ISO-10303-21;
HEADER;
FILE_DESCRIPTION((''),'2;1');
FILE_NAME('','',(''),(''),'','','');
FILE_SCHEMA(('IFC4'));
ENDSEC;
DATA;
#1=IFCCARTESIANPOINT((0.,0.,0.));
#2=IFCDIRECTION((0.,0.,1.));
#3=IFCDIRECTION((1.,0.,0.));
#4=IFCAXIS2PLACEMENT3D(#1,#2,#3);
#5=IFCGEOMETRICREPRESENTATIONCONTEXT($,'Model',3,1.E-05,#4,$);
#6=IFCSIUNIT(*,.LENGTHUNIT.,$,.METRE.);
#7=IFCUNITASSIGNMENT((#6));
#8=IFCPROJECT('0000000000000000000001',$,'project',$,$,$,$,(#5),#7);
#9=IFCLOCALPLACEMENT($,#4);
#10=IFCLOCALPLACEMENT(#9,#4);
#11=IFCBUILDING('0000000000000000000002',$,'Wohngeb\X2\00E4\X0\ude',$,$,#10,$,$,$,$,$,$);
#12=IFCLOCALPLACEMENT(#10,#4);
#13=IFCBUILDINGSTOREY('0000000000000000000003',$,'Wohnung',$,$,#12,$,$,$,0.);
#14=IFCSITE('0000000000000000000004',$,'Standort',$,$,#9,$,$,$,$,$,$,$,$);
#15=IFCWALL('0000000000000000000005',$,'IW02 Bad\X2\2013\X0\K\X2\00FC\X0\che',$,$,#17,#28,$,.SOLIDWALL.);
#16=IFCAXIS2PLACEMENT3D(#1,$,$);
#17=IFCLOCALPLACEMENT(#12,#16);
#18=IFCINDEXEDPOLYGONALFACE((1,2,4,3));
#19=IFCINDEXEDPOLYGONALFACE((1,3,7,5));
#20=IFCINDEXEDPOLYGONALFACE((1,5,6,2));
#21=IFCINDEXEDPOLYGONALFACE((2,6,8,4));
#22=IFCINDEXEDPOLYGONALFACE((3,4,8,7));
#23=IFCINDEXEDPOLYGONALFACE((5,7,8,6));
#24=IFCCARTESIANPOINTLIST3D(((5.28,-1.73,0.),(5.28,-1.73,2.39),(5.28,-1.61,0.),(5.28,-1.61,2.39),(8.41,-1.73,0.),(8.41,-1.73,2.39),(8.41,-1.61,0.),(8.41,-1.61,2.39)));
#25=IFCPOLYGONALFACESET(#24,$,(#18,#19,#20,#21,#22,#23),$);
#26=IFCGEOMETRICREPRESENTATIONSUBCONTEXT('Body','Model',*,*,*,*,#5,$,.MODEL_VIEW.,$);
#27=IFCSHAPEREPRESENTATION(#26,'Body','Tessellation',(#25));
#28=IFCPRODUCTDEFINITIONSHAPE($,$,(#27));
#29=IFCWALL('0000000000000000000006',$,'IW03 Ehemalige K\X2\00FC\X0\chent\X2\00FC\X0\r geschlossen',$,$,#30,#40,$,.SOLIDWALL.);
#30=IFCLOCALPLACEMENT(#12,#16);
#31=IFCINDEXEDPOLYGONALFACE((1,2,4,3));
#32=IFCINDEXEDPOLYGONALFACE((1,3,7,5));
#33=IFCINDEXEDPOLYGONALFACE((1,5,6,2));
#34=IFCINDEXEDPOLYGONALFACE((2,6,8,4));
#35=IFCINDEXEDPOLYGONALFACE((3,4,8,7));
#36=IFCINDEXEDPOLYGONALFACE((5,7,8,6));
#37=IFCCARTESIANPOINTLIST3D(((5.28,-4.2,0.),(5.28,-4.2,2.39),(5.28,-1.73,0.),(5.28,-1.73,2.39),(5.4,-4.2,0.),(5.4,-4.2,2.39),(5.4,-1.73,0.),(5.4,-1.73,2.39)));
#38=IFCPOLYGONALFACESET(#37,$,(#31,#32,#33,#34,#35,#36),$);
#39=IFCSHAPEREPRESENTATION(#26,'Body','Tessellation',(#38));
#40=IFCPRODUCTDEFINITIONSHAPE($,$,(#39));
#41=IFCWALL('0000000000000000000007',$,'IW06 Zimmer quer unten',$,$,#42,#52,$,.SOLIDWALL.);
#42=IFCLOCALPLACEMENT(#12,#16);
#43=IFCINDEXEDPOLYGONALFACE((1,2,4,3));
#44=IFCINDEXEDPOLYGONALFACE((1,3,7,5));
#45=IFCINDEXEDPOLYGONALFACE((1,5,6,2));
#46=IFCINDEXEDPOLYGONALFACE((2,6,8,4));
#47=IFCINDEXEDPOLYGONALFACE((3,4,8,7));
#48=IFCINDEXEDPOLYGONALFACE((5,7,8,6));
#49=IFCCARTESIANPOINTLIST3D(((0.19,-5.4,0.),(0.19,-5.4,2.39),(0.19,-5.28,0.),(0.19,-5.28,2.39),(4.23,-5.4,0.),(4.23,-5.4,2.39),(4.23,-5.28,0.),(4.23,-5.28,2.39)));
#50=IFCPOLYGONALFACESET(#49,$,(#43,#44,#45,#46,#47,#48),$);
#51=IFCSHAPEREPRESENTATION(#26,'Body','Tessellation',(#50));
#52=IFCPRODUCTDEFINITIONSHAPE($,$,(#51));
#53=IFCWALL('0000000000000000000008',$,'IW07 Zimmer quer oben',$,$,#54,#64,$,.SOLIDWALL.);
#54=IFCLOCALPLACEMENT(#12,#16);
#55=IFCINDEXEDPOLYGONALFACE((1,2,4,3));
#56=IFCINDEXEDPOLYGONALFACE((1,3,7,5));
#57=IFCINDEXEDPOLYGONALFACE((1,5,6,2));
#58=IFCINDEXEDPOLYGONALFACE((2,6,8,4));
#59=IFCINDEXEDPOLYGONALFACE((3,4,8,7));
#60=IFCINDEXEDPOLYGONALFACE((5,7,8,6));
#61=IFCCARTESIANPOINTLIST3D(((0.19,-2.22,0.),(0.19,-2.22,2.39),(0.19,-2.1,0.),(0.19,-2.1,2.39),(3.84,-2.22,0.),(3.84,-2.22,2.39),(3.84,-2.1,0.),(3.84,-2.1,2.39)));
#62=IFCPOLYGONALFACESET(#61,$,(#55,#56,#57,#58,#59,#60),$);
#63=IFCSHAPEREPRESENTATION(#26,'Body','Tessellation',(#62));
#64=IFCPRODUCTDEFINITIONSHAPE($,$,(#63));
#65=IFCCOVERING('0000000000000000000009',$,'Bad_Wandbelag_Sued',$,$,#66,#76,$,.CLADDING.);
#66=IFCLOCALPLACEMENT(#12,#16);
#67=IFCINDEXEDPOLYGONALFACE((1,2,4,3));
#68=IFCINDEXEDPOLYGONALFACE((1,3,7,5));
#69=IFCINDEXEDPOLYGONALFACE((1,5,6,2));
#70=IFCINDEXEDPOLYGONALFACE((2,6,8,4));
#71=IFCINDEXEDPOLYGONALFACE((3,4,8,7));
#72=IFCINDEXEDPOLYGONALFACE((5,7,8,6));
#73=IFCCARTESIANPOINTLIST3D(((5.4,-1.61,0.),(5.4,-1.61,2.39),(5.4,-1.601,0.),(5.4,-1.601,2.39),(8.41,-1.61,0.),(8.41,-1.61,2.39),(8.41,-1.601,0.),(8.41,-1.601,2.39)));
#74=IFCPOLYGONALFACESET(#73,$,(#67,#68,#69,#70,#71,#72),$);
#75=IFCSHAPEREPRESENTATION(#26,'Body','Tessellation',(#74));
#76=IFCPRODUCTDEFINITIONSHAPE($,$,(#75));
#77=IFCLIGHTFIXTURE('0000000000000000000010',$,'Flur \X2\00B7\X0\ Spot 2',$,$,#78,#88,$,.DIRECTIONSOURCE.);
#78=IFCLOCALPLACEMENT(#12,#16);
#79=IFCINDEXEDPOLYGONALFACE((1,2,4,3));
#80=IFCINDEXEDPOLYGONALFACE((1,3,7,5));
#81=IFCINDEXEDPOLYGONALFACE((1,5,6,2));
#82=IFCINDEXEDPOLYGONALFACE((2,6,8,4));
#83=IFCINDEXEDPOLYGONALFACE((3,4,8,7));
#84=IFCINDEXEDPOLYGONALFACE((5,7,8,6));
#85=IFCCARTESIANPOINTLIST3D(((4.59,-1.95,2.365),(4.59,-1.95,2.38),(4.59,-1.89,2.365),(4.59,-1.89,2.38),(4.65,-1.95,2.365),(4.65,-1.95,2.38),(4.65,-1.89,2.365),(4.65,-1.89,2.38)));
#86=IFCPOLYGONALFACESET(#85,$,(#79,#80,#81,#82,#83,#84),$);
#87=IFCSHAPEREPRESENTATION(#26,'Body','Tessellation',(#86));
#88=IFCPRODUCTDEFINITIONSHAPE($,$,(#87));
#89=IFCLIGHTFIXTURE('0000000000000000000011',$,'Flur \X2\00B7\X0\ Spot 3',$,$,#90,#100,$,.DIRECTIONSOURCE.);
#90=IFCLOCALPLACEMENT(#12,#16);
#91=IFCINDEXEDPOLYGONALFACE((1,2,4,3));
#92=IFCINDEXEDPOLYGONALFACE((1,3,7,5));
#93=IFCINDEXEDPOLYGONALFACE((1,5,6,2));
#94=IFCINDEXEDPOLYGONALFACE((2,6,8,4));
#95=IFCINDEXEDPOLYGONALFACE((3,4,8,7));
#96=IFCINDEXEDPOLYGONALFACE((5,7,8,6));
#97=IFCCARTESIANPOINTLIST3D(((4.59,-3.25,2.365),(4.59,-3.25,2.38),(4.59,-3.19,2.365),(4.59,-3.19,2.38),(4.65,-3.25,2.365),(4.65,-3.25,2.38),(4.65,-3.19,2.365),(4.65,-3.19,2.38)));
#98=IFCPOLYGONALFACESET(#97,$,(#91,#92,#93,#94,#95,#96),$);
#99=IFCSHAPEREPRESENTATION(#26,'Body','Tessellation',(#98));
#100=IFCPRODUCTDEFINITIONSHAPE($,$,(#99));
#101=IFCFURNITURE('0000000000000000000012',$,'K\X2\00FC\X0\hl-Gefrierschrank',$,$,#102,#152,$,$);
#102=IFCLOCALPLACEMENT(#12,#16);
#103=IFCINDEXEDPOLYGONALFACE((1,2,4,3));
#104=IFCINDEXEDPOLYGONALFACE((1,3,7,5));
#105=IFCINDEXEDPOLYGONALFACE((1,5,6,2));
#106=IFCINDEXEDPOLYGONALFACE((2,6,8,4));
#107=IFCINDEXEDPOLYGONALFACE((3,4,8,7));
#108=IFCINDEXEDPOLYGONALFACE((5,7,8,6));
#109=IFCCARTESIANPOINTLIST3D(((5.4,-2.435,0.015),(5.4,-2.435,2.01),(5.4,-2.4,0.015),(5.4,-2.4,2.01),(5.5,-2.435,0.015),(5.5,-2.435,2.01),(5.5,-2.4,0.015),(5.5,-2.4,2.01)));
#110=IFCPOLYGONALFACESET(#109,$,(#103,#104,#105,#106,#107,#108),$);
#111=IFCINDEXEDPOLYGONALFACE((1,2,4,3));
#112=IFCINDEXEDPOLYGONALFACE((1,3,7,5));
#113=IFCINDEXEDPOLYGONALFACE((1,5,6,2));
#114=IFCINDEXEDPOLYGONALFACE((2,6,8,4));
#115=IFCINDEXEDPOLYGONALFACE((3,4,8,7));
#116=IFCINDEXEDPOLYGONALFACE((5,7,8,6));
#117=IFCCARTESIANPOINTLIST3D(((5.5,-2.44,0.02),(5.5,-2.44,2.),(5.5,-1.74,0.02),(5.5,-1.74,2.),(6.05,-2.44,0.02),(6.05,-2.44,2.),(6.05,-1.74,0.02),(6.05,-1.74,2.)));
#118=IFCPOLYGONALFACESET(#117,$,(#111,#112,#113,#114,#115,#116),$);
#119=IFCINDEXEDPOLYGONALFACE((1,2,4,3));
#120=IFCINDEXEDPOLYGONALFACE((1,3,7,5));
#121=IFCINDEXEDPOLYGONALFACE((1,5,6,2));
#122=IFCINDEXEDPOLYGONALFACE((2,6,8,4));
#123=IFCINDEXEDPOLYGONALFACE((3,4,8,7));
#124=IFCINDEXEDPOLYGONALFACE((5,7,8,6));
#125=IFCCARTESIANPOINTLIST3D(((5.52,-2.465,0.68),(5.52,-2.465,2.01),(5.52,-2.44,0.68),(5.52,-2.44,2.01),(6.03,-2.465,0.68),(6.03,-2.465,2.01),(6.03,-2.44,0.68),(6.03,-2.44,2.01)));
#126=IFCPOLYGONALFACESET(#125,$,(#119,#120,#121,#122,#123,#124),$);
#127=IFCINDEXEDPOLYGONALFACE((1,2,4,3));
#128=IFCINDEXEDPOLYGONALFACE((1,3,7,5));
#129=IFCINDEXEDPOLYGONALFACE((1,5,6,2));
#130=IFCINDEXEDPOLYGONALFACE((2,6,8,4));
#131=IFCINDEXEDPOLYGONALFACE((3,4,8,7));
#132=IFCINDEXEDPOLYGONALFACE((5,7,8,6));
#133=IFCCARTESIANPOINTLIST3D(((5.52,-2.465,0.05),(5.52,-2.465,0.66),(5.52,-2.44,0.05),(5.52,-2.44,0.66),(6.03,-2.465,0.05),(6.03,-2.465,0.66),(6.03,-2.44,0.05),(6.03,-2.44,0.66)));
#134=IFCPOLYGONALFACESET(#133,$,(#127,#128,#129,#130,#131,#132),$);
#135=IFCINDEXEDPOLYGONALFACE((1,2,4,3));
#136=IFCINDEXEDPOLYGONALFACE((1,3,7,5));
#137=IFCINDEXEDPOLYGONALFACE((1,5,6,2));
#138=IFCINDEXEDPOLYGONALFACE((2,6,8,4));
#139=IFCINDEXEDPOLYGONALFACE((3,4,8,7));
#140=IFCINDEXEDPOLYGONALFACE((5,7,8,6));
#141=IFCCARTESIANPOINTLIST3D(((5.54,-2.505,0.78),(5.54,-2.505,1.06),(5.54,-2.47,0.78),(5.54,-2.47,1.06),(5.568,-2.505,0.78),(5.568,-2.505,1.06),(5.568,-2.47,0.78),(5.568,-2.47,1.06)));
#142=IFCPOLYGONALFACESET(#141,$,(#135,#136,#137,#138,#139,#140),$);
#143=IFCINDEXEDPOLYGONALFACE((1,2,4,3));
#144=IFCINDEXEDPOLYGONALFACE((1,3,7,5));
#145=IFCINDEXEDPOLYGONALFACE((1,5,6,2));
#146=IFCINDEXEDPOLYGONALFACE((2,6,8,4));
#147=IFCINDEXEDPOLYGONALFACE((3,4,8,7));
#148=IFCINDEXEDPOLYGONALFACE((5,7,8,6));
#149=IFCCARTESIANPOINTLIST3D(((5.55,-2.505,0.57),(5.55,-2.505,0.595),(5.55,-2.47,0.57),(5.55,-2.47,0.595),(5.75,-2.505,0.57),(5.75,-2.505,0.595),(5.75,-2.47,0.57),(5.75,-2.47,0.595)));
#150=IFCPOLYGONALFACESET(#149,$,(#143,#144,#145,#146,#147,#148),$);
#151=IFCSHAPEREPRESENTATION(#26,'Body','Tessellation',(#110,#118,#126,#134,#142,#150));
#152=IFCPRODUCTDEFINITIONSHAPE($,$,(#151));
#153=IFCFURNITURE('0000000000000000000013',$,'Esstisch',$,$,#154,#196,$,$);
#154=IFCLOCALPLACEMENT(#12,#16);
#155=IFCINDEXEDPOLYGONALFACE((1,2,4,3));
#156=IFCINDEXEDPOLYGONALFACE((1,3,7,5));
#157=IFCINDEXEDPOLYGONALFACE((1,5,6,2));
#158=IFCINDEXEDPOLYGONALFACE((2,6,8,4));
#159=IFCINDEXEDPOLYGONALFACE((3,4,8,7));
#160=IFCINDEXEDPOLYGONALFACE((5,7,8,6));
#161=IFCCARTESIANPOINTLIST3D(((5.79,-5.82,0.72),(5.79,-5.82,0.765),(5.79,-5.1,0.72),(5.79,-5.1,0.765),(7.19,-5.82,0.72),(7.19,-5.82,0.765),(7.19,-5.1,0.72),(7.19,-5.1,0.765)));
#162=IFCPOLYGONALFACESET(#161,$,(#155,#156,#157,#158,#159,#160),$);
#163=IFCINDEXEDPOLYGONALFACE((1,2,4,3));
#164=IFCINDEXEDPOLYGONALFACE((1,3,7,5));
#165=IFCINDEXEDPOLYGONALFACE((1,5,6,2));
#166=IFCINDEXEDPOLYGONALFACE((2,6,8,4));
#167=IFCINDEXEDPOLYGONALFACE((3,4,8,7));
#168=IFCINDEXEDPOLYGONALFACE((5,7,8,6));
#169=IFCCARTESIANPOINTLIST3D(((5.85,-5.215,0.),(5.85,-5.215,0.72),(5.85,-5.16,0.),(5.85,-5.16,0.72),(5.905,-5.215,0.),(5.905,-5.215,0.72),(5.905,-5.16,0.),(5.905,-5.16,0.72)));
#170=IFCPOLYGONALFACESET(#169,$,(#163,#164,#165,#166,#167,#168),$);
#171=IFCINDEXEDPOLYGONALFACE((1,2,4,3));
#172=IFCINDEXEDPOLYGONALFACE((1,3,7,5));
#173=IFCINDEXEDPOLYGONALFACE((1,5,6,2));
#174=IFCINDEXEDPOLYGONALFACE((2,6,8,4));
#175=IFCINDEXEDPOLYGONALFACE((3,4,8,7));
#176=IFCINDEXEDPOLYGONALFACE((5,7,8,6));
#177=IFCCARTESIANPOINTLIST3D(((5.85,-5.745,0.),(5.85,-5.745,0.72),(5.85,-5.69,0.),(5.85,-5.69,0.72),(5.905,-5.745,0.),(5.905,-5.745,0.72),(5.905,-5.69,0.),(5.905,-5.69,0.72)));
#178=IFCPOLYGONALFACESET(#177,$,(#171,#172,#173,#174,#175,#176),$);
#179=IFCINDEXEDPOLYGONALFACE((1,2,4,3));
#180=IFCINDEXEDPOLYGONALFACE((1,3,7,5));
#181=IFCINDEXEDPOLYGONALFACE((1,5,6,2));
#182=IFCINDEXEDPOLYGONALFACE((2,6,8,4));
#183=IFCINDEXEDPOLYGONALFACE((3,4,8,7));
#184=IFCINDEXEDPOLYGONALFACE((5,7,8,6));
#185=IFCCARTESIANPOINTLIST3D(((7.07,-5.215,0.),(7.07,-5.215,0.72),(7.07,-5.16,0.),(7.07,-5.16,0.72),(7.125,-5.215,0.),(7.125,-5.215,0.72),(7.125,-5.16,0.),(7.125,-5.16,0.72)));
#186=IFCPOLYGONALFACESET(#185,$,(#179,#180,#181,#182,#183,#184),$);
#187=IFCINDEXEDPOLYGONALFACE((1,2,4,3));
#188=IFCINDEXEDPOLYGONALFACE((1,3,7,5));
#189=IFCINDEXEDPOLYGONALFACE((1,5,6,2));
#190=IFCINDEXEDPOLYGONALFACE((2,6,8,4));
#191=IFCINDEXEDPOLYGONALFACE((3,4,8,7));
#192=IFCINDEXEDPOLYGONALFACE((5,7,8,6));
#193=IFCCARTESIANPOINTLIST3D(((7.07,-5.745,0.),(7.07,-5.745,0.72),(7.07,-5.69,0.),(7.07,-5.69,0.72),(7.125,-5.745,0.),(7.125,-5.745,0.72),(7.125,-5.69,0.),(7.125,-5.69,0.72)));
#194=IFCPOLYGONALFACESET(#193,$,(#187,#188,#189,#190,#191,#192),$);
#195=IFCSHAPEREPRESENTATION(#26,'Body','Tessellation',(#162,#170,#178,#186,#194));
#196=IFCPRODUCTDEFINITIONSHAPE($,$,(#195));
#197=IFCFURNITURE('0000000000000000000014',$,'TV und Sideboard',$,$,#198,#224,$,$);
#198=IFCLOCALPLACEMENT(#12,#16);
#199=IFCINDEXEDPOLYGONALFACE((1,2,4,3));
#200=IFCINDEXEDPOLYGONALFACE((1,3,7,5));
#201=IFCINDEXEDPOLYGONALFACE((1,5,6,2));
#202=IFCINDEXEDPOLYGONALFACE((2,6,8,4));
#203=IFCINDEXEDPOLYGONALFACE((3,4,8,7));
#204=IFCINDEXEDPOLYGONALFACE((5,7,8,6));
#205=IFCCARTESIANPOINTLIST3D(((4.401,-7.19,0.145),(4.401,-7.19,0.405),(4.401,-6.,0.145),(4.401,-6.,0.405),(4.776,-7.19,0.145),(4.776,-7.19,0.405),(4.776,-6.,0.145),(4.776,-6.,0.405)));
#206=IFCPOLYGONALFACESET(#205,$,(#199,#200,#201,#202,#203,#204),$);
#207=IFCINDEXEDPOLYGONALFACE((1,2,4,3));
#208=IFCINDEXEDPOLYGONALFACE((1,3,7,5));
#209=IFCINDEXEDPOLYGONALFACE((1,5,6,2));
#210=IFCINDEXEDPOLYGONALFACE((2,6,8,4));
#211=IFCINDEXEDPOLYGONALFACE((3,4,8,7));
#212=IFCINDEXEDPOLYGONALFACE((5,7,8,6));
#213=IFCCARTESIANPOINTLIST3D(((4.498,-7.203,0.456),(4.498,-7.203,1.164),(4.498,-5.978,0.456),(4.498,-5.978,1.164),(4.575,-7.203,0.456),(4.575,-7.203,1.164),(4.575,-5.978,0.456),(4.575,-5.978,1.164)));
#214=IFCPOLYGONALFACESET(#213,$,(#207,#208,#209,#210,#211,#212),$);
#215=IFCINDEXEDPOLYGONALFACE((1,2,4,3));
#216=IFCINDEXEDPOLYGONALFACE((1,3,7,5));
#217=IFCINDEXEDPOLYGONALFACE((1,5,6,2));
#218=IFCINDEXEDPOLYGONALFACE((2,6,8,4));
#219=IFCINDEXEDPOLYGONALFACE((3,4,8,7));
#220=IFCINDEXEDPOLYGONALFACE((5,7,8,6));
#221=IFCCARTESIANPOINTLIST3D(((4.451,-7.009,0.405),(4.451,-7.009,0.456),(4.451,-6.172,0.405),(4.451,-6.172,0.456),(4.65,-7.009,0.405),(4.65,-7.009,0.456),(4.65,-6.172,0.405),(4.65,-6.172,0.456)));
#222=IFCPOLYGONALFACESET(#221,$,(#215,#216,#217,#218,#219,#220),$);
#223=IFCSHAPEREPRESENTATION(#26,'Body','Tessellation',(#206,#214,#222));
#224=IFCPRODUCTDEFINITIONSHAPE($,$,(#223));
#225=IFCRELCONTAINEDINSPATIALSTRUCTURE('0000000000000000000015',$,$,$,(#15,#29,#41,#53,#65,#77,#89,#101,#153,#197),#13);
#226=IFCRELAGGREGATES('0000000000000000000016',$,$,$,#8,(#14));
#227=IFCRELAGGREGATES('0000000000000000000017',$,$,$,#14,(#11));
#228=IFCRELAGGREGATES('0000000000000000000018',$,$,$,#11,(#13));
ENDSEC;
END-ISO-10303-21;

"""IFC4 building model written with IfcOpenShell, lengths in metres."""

from ifc_helpers import new_model, si_unit, frame, origin, origin_with_axes, place, context, subcontext, project, spatial, polyline, outline, extrude, element, save


model = new_model("IFC4")

# Units and contexts
model_context = context("Model", 3, precision=1e-05, world=origin_with_axes())
body_context = subcontext(model_context, "Body", "Model", "MODEL_VIEW")
ifc_project = project(units=[si_unit("LENGTHUNIT", "METRE")], contexts=[model_context])

# Site, building, storey
site_placement = place(None, origin_with_axes())
site = spatial("IfcSite", under=ifc_project, at=site_placement, Name="Standort")
building_placement = place(site_placement, origin_with_axes())
building = spatial("IfcBuilding", under=site, at=building_placement, Name="Wohngebäude")
storey_placement = place(building_placement, origin_with_axes())
storey = spatial("IfcBuildingStorey", under=building, at=storey_placement, Name="Wohnung", Elevation=0.0)

# Walls
wall_1_placement = place(storey_placement, frame((5.28, -1.61, 0.0), z_axis=(0.0, 0.0, 1.0), x_axis=(1.0, 0.0, 0.0)))
element("IfcWall", 1, at=wall_1_placement, inside=storey, Name="IW02 Bad–Küche", PredefinedType="SOLIDWALL", context=body_context, shape_type="SweptSolid", body=[
    extrude(outline(polyline([(0.0, 0.0), (0.0, -0.12), (3.13, -0.12), (3.13, 0.0), (0.0, 0.0)])), origin(), (0.0, 0.0, 1.0), 2.39),
])
wall_2_placement = place(storey_placement, frame((5.28, -1.73, 0.0), z_axis=(0.0, 0.0, 1.0), x_axis=(1.0, 0.0, 0.0)))
element("IfcWall", 2, at=wall_2_placement, inside=storey, Name="IW03 Ehemalige Küchentür geschlossen", PredefinedType="SOLIDWALL", context=body_context, shape_type="SweptSolid", body=[
    extrude(outline(polyline([(0.0, 0.0), (0.0, -2.47), (0.12, -2.47), (0.12, 0.0), (0.0, 0.0)])), origin(), (0.0, 0.0, 1.0), 2.39),
])

# Walls
wall_3_placement = place(storey_placement, frame((0.19, -5.28, 0.0), z_axis=(0.0, 0.0, 1.0), x_axis=(1.0, 0.0, 0.0)))
element("IfcWall", 3, at=wall_3_placement, inside=storey, Name="IW06 Zimmer quer unten", PredefinedType="SOLIDWALL", context=body_context, shape_type="SweptSolid", body=[
    extrude(outline(polyline([(0.0, 0.0), (0.0, -0.12), (4.04, -0.12), (4.04, 0.0), (0.0, 0.0)])), origin(), (0.0, 0.0, 1.0), 2.39),
])
wall_4_placement = place(storey_placement, frame((0.19, -2.1, 0.0), z_axis=(0.0, 0.0, 1.0), x_axis=(1.0, 0.0, 0.0)))
element("IfcWall", 4, at=wall_4_placement, inside=storey, Name="IW07 Zimmer quer oben", PredefinedType="SOLIDWALL", context=body_context, shape_type="SweptSolid", body=[
    extrude(outline(polyline([(0.0, 0.0), (0.0, -0.12), (3.65, -0.12), (3.65, 0.0), (0.0, 0.0)])), origin(), (0.0, 0.0, 1.0), 2.39),
])

# Covering
covering_placement = place(storey_placement, frame((5.4, -1.601, 0.0), z_axis=(0.0, 0.0, 1.0), x_axis=(1.0, 0.0, 0.0)))
element("IfcCovering", 5, at=covering_placement, inside=storey, Name="Bad_Wandbelag_Sued", PredefinedType="CLADDING", context=body_context, shape_type="SweptSolid", body=[
    extrude(outline(polyline([(0.0, 0.0), (0.0, -0.009), (3.01, -0.009), (3.01, 0.0), (0.0, 0.0)])), origin(), (0.0, 0.0, 1.0), 2.39),
])

# Light fixtures
for number, where, z_axis, x_axis, name in (
    (6, (4.59, -1.89, 2.365), (0.0, 0.0, 1.0), (1.0, 0.0, 0.0), "Flur · Spot 2"),
    (7, (4.59, -3.19, 2.365), (0.0, 0.0, 1.0), (1.0, 0.0, 0.0), "Flur · Spot 3"),
):
    element("IfcLightFixture", number, at=place(storey_placement, frame(where, z_axis=z_axis, x_axis=x_axis)), inside=storey, Name=name, PredefinedType="DIRECTIONSOURCE", context=body_context, shape_type="SweptSolid", body=[
        extrude(outline(polyline([(0.0, 0.0), (0.0, -0.06), (0.06, -0.06), (0.06, 0.0), (0.0, 0.0)])), origin(), (0.0, 0.0, 1.0), 0.015),
    ])

# Furniture
furniture_1_placement = place(storey_placement, frame((5.4, -1.74, 0.015), z_axis=(0.0, 0.0, 1.0), x_axis=(1.0, 0.0, 0.0)))
element("IfcFurniture", 8, at=furniture_1_placement, inside=storey, Name="Kühl-Gefrierschrank", context=body_context, shape_type="SweptSolid", body=[
    extrude(outline(polyline([(0.0, -0.66), (0.0, -0.695), (0.1, -0.695), (0.1, -0.66), (0.0, -0.66)])), origin(), (0.0, 0.0, 1.0), 1.995),
    extrude(outline(polyline([(0.1, 0.0), (0.1, -0.7), (0.65, -0.7), (0.65, 0.0), (0.1, 0.0)])), frame((0.0, 0.0, 0.005)), (0.0, 0.0, 1.0), 1.98),
    extrude(outline(polyline([(0.12, -0.7), (0.12, -0.725), (0.63, -0.725), (0.63, -0.7), (0.12, -0.7)])), frame((0.0, 0.0, 0.665)), (0.0, 0.0, 1.0), 1.33),
    extrude(outline(polyline([(0.12, -0.7), (0.12, -0.725), (0.63, -0.725), (0.63, -0.7), (0.12, -0.7)])), frame((0.0, 0.0, 0.035)), (0.0, 0.0, 1.0), 0.61),
    extrude(outline(polyline([(0.14, -0.73), (0.14, -0.765), (0.168, -0.765), (0.168, -0.73), (0.14, -0.73)])), frame((0.0, 0.0, 0.765)), (0.0, 0.0, 1.0), 0.28),
    extrude(outline(polyline([(0.15, -0.73), (0.15, -0.765), (0.35, -0.765), (0.35, -0.73), (0.15, -0.73)])), frame((0.0, 0.0, 0.555)), (0.0, 0.0, 1.0), 0.025),
])
furniture_2_placement = place(storey_placement, frame((5.79, -5.1, 0.0), z_axis=(0.0, 0.0, 1.0), x_axis=(1.0, 0.0, 0.0)))
element("IfcFurniture", 9, at=furniture_2_placement, inside=storey, Name="Esstisch", context=body_context, shape_type="SweptSolid", body=[
    extrude(outline(polyline([(0.0, 0.0), (0.0, -0.72), (1.4, -0.72), (1.4, 0.0), (0.0, 0.0)])), frame((0.0, 0.0, 0.72)), (0.0, 0.0, 1.0), 0.045),
    extrude(outline(polyline([(0.06, -0.06), (0.06, -0.115), (0.115, -0.115), (0.115, -0.06), (0.06, -0.06)])), origin(), (0.0, 0.0, 1.0), 0.72),
    extrude(outline(polyline([(0.06, -0.59), (0.06, -0.645), (0.115, -0.645), (0.115, -0.59), (0.06, -0.59)])), origin(), (0.0, 0.0, 1.0), 0.72),
    extrude(outline(polyline([(1.28, -0.06), (1.28, -0.115), (1.335, -0.115), (1.335, -0.06), (1.28, -0.06)])), origin(), (0.0, 0.0, 1.0), 0.72),
    extrude(outline(polyline([(1.28, -0.59), (1.28, -0.645), (1.335, -0.645), (1.335, -0.59), (1.28, -0.59)])), origin(), (0.0, 0.0, 1.0), 0.72),
])
furniture_3_placement = place(storey_placement, frame((4.401, -5.978, 0.145), z_axis=(0.0, 0.0, 1.0), x_axis=(1.0, 0.0, 0.0)))
element("IfcFurniture", 10, at=furniture_3_placement, inside=storey, Name="TV und Sideboard", context=body_context, shape_type="SweptSolid", body=[
    extrude(outline(polyline([(0.0, -0.022), (0.0, -1.212), (0.375, -1.212), (0.375, -0.022), (0.0, -0.022)])), origin(), (0.0, 0.0, 1.0), 0.26),
    extrude(outline(polyline([(0.097, 0.0), (0.097, -1.225), (0.174, -1.225), (0.174, 0.0), (0.097, 0.0)])), frame((0.0, 0.0, 0.311)), (0.0, 0.0, 1.0), 0.708),
    extrude(outline(polyline([(0.05, -0.194), (0.05, -1.031), (0.249, -1.031), (0.249, -0.194), (0.05, -0.194)])), frame((0.0, 0.0, 0.26)), (0.0, 0.0, 1.0), 0.051),
])

save(model, "model.ifc")
